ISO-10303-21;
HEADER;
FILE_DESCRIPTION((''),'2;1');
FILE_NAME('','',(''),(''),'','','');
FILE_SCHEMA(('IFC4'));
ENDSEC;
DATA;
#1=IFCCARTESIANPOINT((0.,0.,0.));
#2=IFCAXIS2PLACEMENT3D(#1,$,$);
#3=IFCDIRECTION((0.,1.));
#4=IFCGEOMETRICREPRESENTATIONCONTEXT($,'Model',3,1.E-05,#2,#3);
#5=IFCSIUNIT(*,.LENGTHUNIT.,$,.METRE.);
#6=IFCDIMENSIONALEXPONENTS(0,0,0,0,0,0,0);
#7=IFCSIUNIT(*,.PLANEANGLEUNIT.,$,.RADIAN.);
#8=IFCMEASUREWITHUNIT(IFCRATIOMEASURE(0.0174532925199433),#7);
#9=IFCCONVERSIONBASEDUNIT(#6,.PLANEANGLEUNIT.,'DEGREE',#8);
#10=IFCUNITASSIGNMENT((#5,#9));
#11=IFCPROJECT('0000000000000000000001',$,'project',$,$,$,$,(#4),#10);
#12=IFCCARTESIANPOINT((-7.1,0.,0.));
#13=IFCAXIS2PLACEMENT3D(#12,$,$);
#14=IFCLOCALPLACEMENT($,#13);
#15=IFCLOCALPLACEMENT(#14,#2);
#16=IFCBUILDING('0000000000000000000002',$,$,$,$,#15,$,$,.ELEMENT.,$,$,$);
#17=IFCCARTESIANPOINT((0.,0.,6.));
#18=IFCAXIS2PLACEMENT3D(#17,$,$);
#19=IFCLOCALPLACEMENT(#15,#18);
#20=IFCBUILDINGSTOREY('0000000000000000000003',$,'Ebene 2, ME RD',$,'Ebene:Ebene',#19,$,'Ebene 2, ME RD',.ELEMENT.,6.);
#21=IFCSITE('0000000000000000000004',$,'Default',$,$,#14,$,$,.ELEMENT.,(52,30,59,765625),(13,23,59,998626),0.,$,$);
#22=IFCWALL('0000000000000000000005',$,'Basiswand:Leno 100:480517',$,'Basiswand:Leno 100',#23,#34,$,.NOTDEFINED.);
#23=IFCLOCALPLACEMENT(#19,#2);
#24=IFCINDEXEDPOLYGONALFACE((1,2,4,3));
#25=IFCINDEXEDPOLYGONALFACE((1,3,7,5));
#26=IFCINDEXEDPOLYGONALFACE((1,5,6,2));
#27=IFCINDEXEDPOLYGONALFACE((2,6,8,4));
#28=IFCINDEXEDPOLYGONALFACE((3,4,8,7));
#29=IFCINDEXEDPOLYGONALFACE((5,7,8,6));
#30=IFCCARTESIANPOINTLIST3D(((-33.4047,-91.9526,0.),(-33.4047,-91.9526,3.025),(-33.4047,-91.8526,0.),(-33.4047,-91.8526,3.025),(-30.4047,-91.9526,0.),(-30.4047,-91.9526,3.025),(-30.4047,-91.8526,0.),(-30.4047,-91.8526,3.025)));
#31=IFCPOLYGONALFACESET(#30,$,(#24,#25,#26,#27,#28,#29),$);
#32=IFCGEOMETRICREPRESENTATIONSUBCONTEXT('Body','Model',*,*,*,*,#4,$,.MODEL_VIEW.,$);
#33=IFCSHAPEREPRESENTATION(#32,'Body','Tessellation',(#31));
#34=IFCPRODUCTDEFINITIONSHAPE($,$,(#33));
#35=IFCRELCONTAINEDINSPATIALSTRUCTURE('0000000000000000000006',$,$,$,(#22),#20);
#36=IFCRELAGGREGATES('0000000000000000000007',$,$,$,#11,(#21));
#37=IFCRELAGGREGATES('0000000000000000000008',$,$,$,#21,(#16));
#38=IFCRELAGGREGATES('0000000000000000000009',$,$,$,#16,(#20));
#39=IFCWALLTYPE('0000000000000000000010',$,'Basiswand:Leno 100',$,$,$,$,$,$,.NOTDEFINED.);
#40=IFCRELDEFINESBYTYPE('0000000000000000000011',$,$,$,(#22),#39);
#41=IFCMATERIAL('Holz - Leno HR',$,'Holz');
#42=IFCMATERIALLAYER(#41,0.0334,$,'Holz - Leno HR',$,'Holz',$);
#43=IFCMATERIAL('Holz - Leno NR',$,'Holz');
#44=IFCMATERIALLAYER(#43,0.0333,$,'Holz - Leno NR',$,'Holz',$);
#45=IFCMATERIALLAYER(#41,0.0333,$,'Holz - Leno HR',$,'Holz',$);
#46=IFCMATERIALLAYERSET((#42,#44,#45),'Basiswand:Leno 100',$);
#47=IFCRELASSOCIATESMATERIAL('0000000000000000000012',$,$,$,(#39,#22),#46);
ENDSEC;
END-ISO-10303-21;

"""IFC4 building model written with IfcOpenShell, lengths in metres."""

from ifc_helpers import new_model, entity, si_unit, converted_unit, direction, frame, origin, place, context, subcontext, project, spatial, indexed_curve, outline, extrude, material, layer, layer_set, type_object, element, save


model = new_model("IFC4")

# Units and contexts
model_context = context("Model", 3, precision=1e-05, world=origin(), true_north=direction((0.0, 1.0)))
body_context = subcontext(model_context, "Body", "Model", "MODEL_VIEW")
ifc_project = project(units=[si_unit("LENGTHUNIT", "METRE"), converted_unit("PLANEANGLEUNIT", "DEGREE", entity("IfcRatioMeasure", 0.0174532925199433), si_unit("PLANEANGLEUNIT", "RADIAN"), dimensions=[0, 0, 0, 0, 0, 0, 0])], contexts=[model_context])

# Site, building, storey
site_placement = place(None, frame((-7.1, 0.0, 0.0)))
site = spatial("IfcSite", under=ifc_project, at=site_placement, Name="Default", CompositionType="ELEMENT", RefLatitude=(52, 30, 59, 765625), RefLongitude=(13, 23, 59, 998626), RefElevation=0.0)
building_placement = place(site_placement, origin())
building = spatial("IfcBuilding", under=site, at=building_placement, CompositionType="ELEMENT")
storey_placement = place(building_placement, frame((0.0, 0.0, 6.0)))
storey = spatial("IfcBuildingStorey", under=building, at=storey_placement, Name="Ebene 2, ME RD", ObjectType="Ebene:Ebene", LongName="Ebene 2, ME RD", CompositionType="ELEMENT", Elevation=6.0)

# Wall
ifc_material_1 = material(Name="Holz - Leno HR", Category="Holz")
ifc_layer_1 = layer(ifc_material_1, 0.0334, Name="Holz - Leno HR", Category="Holz")
ifc_material_2 = material(Name="Holz - Leno NR", Category="Holz")
ifc_layer_2 = layer(ifc_material_2, 0.0333, Name="Holz - Leno NR", Category="Holz")
ifc_layer_3 = layer(ifc_material_1, 0.0333, Name="Holz - Leno HR", Category="Holz")
ifc_layer_set = layer_set([ifc_layer_1, ifc_layer_2, ifc_layer_3], Name="Basiswand:Leno 100")
wall_type = type_object("IfcWallType", Name="Basiswand:Leno 100", PredefinedType="NOTDEFINED", material=ifc_layer_set)
wall_placement = place(storey_placement, frame((-30.4047, -91.9026, 0.0), z_axis=(0.0, 0.0, 1.0), x_axis=(-1.0, 0.0, 0.0)))
element("IfcWall", 1, at=wall_placement, inside=storey, type_object=wall_type, material=ifc_layer_set, Name="Basiswand:Leno 100:480517", ObjectType="Basiswand:Leno 100", PredefinedType="NOTDEFINED", context=body_context, shape_type="SweptSolid", body=[
    extrude(outline(indexed_curve([(3.0, 0.05), (0.0, 0.05), (0.0, -0.05), (3.0, -0.05), (3.0, 0.05)], self_intersect=False)), origin(), (0.0, 0.0, 1.0), 3.025),
])

save(model, "model.ifc")
